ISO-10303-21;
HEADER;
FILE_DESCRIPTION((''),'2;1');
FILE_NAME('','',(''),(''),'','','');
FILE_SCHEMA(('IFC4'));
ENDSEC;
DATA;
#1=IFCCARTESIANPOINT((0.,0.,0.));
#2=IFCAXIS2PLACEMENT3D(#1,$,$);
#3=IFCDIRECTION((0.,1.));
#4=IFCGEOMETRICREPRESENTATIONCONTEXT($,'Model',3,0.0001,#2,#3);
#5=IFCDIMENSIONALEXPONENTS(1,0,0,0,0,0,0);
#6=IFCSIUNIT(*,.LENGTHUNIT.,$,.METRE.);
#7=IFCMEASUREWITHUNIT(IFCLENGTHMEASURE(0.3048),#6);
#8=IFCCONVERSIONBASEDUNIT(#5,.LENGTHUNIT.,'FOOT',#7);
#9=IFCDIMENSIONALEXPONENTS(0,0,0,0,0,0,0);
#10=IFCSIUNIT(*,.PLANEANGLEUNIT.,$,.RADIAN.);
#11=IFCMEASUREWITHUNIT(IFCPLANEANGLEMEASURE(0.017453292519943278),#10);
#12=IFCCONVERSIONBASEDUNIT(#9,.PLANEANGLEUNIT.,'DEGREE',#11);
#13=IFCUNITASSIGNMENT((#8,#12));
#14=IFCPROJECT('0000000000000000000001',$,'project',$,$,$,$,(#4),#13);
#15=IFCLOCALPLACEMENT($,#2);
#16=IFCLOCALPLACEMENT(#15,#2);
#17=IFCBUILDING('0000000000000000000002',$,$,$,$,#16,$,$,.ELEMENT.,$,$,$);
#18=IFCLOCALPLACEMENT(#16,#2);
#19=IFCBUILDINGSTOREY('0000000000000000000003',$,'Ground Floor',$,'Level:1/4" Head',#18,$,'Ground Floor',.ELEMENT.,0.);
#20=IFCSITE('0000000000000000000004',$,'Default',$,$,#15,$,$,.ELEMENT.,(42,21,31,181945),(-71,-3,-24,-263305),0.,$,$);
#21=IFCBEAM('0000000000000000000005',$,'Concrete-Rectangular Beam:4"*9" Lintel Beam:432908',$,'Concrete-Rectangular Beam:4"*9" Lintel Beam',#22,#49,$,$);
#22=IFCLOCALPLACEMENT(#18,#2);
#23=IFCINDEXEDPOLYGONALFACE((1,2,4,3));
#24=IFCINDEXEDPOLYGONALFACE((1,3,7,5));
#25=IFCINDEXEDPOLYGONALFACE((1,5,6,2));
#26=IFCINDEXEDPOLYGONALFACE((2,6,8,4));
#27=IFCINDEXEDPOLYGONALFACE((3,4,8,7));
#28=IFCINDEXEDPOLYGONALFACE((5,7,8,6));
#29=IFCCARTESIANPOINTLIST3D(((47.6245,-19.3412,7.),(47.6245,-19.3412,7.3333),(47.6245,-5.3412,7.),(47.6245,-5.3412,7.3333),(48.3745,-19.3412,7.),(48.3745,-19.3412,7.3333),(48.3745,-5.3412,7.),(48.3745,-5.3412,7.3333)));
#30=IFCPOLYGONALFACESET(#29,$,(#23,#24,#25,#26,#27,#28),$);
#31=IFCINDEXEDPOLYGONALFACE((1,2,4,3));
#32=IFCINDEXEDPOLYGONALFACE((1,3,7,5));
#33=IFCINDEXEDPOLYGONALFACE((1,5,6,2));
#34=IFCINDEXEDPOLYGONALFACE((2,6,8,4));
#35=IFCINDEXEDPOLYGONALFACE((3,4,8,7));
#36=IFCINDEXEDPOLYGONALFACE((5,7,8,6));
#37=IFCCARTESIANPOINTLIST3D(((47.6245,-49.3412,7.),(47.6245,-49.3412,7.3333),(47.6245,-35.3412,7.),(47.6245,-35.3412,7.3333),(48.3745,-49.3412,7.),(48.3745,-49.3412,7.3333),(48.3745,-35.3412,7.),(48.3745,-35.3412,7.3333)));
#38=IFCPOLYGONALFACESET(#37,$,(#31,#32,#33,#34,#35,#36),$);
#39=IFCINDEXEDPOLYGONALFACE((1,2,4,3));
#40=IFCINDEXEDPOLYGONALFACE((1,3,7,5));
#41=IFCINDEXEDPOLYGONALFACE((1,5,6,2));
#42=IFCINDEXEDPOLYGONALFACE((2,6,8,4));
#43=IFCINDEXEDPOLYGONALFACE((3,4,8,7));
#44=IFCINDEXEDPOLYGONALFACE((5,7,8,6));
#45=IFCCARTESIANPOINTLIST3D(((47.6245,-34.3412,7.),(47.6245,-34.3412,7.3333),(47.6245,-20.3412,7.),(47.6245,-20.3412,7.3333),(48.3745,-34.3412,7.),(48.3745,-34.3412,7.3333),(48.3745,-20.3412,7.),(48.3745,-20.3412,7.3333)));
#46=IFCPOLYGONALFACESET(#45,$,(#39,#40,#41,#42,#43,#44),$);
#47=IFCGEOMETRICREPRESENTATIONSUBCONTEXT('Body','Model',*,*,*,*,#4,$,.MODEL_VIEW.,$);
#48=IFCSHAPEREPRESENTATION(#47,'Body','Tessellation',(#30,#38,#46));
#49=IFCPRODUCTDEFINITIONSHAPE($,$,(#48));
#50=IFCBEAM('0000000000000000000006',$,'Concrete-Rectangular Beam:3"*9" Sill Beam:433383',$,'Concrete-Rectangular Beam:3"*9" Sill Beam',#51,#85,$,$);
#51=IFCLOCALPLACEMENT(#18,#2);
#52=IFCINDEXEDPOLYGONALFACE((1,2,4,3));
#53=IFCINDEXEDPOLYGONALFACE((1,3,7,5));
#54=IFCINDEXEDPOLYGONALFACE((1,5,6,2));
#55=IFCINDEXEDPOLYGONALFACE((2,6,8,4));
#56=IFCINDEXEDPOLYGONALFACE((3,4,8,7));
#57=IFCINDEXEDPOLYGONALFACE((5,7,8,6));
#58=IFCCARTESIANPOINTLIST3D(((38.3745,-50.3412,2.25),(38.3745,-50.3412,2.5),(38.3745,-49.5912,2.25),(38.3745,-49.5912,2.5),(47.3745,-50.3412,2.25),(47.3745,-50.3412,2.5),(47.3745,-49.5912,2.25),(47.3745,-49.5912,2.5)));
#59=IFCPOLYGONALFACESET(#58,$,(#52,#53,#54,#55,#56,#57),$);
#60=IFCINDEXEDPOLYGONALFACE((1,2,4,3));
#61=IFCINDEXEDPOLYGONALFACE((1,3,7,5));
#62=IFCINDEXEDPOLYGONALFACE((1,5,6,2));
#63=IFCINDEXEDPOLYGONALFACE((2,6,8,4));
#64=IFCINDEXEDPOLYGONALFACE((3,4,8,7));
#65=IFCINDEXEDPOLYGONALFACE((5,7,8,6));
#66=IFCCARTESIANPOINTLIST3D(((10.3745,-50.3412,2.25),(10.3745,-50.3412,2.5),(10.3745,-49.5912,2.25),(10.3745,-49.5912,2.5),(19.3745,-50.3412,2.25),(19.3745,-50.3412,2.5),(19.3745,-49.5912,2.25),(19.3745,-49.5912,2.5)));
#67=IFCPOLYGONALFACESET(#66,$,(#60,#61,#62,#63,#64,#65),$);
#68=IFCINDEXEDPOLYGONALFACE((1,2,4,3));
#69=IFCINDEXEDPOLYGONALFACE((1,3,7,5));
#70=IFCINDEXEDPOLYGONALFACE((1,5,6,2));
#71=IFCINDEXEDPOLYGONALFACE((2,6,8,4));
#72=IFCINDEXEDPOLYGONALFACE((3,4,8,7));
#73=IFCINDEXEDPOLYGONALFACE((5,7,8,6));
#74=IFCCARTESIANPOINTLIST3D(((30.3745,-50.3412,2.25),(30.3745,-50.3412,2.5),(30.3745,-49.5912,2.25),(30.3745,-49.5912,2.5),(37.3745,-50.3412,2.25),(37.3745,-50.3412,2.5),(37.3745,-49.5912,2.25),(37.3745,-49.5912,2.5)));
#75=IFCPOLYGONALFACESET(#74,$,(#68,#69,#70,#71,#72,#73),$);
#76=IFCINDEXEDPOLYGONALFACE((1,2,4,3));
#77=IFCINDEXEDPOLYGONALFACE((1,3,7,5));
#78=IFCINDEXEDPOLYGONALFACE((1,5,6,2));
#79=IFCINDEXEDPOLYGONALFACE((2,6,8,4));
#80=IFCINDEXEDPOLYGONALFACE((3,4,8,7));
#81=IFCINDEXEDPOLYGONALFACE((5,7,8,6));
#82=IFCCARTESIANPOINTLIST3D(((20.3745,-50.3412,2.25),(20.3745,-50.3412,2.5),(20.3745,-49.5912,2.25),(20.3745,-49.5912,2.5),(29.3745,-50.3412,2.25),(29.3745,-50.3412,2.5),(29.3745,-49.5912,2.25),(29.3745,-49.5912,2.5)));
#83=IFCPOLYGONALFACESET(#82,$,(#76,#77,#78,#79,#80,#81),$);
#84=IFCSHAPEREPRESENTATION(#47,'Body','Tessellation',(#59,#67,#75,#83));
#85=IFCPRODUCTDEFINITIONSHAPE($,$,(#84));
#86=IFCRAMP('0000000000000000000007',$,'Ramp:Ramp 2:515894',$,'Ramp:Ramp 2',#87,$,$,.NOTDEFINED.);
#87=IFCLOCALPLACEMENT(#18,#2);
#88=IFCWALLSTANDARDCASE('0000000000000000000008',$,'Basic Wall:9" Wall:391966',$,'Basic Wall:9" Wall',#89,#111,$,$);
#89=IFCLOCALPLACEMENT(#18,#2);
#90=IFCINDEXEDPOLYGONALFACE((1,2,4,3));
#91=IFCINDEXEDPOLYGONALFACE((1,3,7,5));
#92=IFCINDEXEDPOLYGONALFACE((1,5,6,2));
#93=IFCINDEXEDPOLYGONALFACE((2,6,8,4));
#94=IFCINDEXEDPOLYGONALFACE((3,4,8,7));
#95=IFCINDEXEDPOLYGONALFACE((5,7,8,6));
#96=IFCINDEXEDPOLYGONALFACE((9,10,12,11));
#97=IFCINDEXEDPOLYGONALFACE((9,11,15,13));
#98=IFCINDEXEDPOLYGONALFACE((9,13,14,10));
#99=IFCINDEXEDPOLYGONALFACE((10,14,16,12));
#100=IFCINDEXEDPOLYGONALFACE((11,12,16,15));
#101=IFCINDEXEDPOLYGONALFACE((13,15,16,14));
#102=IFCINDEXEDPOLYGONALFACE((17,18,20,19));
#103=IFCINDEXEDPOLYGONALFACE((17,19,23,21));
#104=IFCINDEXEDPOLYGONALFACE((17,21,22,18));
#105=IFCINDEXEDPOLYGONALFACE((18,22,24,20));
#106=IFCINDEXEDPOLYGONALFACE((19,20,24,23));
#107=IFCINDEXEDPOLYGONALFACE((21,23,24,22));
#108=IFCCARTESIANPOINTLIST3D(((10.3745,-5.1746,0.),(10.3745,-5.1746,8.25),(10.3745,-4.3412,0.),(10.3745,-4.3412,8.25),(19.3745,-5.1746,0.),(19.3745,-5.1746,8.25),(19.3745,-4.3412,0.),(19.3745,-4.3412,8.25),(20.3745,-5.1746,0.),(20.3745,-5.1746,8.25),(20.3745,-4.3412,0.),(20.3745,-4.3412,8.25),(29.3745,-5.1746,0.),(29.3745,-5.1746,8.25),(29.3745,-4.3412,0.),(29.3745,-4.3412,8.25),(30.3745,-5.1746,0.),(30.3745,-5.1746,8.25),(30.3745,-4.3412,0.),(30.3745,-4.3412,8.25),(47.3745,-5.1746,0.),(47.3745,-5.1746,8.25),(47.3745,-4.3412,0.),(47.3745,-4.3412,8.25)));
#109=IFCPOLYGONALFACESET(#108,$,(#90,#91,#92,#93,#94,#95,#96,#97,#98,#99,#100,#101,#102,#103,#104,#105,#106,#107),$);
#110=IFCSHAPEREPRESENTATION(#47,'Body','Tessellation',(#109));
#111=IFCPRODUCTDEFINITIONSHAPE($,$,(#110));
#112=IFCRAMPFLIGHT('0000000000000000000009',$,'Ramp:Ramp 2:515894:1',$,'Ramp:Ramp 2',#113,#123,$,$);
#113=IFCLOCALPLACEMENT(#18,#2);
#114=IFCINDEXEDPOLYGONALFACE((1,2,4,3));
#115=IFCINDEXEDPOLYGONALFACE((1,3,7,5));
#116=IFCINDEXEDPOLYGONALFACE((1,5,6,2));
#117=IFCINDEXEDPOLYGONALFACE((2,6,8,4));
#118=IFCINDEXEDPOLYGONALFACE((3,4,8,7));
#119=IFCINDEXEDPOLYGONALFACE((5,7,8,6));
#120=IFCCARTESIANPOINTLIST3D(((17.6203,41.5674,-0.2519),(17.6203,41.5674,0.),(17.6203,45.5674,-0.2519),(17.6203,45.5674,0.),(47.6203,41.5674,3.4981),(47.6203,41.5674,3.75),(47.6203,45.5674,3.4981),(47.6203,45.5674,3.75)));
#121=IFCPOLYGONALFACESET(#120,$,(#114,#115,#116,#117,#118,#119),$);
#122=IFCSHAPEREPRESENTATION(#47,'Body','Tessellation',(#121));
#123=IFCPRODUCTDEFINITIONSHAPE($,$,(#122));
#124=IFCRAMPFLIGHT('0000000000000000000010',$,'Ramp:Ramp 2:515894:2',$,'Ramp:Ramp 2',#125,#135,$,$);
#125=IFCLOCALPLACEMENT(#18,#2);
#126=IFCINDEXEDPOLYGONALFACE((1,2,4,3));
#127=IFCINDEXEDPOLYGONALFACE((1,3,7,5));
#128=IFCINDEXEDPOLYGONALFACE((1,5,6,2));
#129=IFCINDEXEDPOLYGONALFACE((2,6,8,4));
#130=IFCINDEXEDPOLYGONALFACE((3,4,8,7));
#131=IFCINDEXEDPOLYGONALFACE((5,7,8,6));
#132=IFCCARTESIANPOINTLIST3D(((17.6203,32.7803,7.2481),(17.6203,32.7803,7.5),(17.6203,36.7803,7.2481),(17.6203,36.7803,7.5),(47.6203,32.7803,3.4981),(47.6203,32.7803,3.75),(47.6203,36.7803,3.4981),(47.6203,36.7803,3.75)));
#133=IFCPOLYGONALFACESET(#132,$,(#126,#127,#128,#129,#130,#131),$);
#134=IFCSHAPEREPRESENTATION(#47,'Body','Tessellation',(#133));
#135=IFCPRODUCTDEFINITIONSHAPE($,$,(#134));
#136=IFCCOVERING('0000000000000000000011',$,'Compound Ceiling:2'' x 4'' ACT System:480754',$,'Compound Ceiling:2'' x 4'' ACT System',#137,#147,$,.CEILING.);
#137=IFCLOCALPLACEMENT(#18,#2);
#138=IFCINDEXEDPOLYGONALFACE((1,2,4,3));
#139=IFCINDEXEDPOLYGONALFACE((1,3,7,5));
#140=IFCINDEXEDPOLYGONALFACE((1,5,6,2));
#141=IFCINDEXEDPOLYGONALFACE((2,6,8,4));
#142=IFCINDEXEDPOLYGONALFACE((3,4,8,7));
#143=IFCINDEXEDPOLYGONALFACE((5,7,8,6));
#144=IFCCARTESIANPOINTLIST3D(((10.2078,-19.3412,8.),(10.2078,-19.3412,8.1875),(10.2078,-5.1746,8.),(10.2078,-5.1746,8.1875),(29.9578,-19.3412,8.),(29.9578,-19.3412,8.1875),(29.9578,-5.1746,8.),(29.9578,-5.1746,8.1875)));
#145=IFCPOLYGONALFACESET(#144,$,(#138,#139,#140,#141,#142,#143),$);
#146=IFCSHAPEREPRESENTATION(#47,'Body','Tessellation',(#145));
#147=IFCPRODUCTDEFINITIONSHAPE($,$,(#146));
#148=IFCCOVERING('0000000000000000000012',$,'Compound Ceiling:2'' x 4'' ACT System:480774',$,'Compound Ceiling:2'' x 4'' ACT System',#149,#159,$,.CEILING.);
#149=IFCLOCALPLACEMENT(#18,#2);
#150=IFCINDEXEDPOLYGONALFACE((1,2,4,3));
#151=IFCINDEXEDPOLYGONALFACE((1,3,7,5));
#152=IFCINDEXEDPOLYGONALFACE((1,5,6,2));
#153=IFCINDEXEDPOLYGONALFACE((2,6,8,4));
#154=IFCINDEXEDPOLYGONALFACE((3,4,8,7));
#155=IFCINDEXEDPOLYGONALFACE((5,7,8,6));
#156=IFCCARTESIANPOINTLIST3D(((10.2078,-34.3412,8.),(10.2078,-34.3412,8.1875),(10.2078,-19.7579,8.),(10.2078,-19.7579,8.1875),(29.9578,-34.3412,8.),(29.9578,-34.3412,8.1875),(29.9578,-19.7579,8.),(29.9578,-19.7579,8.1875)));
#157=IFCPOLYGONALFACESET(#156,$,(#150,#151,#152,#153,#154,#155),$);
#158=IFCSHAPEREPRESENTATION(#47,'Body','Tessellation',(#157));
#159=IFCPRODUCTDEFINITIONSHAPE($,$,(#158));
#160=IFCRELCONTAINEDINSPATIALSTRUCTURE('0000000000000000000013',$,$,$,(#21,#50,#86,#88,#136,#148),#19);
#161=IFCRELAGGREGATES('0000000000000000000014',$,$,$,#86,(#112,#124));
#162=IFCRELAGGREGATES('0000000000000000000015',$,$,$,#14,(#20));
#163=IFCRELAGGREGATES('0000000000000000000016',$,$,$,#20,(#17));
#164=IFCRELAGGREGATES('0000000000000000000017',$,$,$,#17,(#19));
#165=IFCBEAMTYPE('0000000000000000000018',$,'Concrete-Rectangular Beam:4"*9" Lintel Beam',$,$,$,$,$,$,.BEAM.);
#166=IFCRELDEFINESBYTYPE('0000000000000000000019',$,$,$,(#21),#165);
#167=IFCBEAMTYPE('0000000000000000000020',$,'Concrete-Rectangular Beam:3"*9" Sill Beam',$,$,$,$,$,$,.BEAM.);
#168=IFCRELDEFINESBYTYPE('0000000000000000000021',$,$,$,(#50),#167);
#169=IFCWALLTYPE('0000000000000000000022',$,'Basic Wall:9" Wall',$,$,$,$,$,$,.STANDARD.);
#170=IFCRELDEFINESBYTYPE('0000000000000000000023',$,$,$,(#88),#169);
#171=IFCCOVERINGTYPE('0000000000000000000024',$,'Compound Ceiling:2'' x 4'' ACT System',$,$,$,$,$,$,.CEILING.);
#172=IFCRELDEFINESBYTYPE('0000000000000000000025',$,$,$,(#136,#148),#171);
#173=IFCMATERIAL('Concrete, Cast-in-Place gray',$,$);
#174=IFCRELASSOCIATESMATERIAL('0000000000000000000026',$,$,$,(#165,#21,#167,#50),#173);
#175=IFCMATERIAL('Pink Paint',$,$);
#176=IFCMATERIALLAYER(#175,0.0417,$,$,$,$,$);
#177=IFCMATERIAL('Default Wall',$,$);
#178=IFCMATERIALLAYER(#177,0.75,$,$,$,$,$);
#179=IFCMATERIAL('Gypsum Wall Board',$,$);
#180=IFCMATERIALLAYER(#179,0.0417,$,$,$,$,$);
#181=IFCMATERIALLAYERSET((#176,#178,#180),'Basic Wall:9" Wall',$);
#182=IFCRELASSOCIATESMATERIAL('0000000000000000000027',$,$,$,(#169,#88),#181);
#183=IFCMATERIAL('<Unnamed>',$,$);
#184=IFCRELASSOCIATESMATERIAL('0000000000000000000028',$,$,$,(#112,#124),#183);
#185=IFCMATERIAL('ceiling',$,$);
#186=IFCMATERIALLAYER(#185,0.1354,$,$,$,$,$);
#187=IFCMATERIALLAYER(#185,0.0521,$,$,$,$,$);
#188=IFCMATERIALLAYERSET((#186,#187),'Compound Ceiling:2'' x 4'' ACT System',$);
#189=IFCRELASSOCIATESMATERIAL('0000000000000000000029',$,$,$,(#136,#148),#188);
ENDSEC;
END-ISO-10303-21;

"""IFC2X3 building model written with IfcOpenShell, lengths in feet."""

from ifc_helpers import new_model, entity, si_unit, converted_unit, direction, frame, frame_2d, origin, place, context, subcontext, project, spatial, polyline, rectangle, outline, extrude, clip, bounded_halfspace, source, transform, mapped, material, layer, layer_set, layer_usage, type_object, type_shapes, element, aggregate, save


model = new_model("IFC2X3")

# Units and contexts
model_context = context("Model", 3, precision=0.0001, world=origin(), true_north=direction((0.0, 1.0)))
body_context = subcontext(model_context, "Body", "Model", "MODEL_VIEW")
ifc_project = project(units=[converted_unit("LENGTHUNIT", "FOOT", entity("IfcLengthMeasure", 0.3048), si_unit("LENGTHUNIT", "METRE"), dimensions=[1, 0, 0, 0, 0, 0, 0]), converted_unit("PLANEANGLEUNIT", "DEGREE", entity("IfcPlaneAngleMeasure", 0.017453292519943278), si_unit("PLANEANGLEUNIT", "RADIAN"), dimensions=[0, 0, 0, 0, 0, 0, 0])], contexts=[model_context])

# Site, building, storey
site_placement = place(None, origin())
site = spatial("IfcSite", under=ifc_project, at=site_placement, Name="Default", CompositionType="ELEMENT", RefLatitude=(42, 21, 31, 181945), RefLongitude=(-71, -3, -24, -263305), RefElevation=0.0)
building_placement = place(site_placement, origin())
building = spatial("IfcBuilding", under=site, at=building_placement, CompositionType="ELEMENT")
storey_placement = place(building_placement, origin())
storey = spatial("IfcBuildingStorey", under=building, at=storey_placement, Name="Ground Floor", ObjectType="Level:1/4\" Head", LongName="Ground Floor", CompositionType="ELEMENT", Elevation=0.0)

# Beams
ifc_material_1 = material(Name="Concrete, Cast-in-Place gray")
beam_type_1 = type_object("IfcBeamType", Name="Concrete-Rectangular Beam:4\"*9\" Lintel Beam", PredefinedType="BEAM", material=ifc_material_1)
shared_shape_1 = source(origin(), body_context, "Body", "SweptSolid", [
    extrude(rectangle(XDim=0.3333, YDim=0.75, at=frame_2d((0.0, 0.0), x_axis=(0.0, 1.0))), frame((47.9995, -19.3412, 7.1667), z_axis=(0.0, 1.0, 0.0), x_axis=(-1.0, 0.0, 0.0)), (0.0, 0.0, 1.0), 14.0),
    extrude(rectangle(XDim=0.3333, YDim=0.75, at=frame_2d((0.0, 0.0), x_axis=(0.0, 1.0))), frame((47.9995, -49.3412, 7.1667), z_axis=(0.0, 1.0, 0.0), x_axis=(-1.0, 0.0, 0.0)), (0.0, 0.0, 1.0), 14.0),
    extrude(rectangle(XDim=0.3333, YDim=0.75, at=frame_2d((0.0, 0.0), x_axis=(0.0, 1.0))), frame((47.9995, -34.3412, 7.1667), z_axis=(0.0, 1.0, 0.0), x_axis=(-1.0, 0.0, 0.0)), (0.0, 0.0, 1.0), 14.0),
])
type_shapes(beam_type_1, [shared_shape_1])
beam_1_placement = place(storey_placement, origin())
element("IfcBeam", 1, at=beam_1_placement, inside=storey, type_object=beam_type_1, material=ifc_material_1, Name="Concrete-Rectangular Beam:4\"*9\" Lintel Beam:432908", ObjectType="Concrete-Rectangular Beam:4\"*9\" Lintel Beam", context=body_context, shape_type="MappedRepresentation", body=[
    mapped(shared_shape_1, transform((0.0, 0.0, 0.0), scale=1.0)),
])
beam_type_2 = type_object("IfcBeamType", Name="Concrete-Rectangular Beam:3\"*9\" Sill Beam", PredefinedType="BEAM", material=ifc_material_1)
shared_shape_2 = source(origin(), body_context, "Body", "SweptSolid", [
    extrude(rectangle(XDim=0.25, YDim=0.75, at=frame_2d((0.0, 0.0), x_axis=(1.0, 0.0))), frame((38.3745, -49.9662, 2.375), z_axis=(1.0, 0.0, 0.0), x_axis=(0.0, 0.0, -1.0)), (0.0, 0.0, 1.0), 9.0),
    extrude(rectangle(XDim=0.25, YDim=0.75, at=frame_2d((0.0, 0.0), x_axis=(1.0, 0.0))), frame((10.3745, -49.9662, 2.375), z_axis=(1.0, 0.0, 0.0), x_axis=(0.0, 0.0, -1.0)), (0.0, 0.0, 1.0), 9.0),
    extrude(rectangle(XDim=0.25, YDim=0.75, at=frame_2d((0.0, 0.0), x_axis=(1.0, 0.0))), frame((30.3745, -49.9662, 2.375), z_axis=(1.0, 0.0, 0.0), x_axis=(0.0, 0.0, -1.0)), (0.0, 0.0, 1.0), 7.0),
    extrude(rectangle(XDim=0.25, YDim=0.75, at=frame_2d((0.0, 0.0), x_axis=(1.0, 0.0))), frame((20.3745, -49.9662, 2.375), z_axis=(1.0, 0.0, 0.0), x_axis=(0.0, 0.0, -1.0)), (0.0, 0.0, 1.0), 9.0),
])
type_shapes(beam_type_2, [shared_shape_2])
beam_2_placement = place(storey_placement, origin())
element("IfcBeam", 2, at=beam_2_placement, inside=storey, type_object=beam_type_2, material=ifc_material_1, Name="Concrete-Rectangular Beam:3\"*9\" Sill Beam:433383", ObjectType="Concrete-Rectangular Beam:3\"*9\" Sill Beam", context=body_context, shape_type="MappedRepresentation", body=[
    mapped(shared_shape_2, transform((0.0, 0.0, 0.0), scale=1.0)),
])

# Shared definitions
ifc_material_2 = material(Name="<Unnamed>")

# Ramp
ramp_1_placement = place(storey_placement, origin())
ramp_1 = element("IfcRamp", 3, at=ramp_1_placement, inside=storey, Name="Ramp:Ramp 2:515894", ObjectType="Ramp:Ramp 2", ShapeType="NOTDEFINED")

# Wall, openings
ifc_material_3 = material(Name="Pink Paint")
ifc_layer_1 = layer(ifc_material_3, 0.0417)
ifc_material_4 = material(Name="Default Wall")
ifc_layer_2 = layer(ifc_material_4, 0.75)
ifc_material_5 = material(Name="Gypsum Wall Board")
ifc_layer_3 = layer(ifc_material_5, 0.0417)
ifc_layer_set_1 = layer_set([ifc_layer_1, ifc_layer_2, ifc_layer_3], Name="Basic Wall:9\" Wall")
ifc_layer_usage_1 = layer_usage(ifc_layer_set_1, "AXIS2", "NEGATIVE", 0.4167)
wall_type = type_object("IfcWallType", Name="Basic Wall:9\" Wall", PredefinedType="STANDARD", material=ifc_layer_set_1)
wall_placement = place(storey_placement, frame((10.3745, -4.7579, 0.0)))
wall = element("IfcWallStandardCase", 4, at=wall_placement, inside=storey, type_object=wall_type, material=ifc_layer_usage_1, Name="Basic Wall:9\" Wall:391966", ObjectType="Basic Wall:9\" Wall", context=body_context, shape_type="Clipping", body=[
    clip(clip(extrude(rectangle(XDim=37.0, YDim=0.8333, at=frame_2d((18.5, 0.0), x_axis=(-1.0, 0.0))), origin(), (0.0, 0.0, 1.0), 8.25), bounded_halfspace(frame((0.0, -0.4167, 0.0), z_axis=(1.0, 0.0, 0.0), x_axis=(0.0, 0.0, -1.0)), True, frame((0.0, -0.4167, 0.0), z_axis=(1.0, 0.0, 0.0), x_axis=(0.0, 0.0, -1.0)), polyline([(0.0, 0.0), (0.0, 0.8333), (-8.25, 0.8333), (-8.25, 0.0), (0.0, 0.0)]))), bounded_halfspace(frame((37.0, -0.4167, 8.25), z_axis=(-1.0, 0.0, 0.0), x_axis=(0.0, 0.0, -1.0)), True, frame((37.0, -0.4167, 8.25), z_axis=(-1.0, 0.0, 0.0), x_axis=(0.0, 0.0, -1.0)), polyline([(0.0, 0.0), (0.0, -0.8333), (8.25, -0.8333), (8.25, 0.0), (0.0, 0.0)]))),
])
opening_1_placement = place(storey_placement, frame((10.3745, -4.7579, 0.0)))
element("IfcOpeningElement", 5, at=opening_1_placement, cuts=wall, ObjectType="Opening", context=body_context, shape_type="SweptSolid", body=[
    extrude(rectangle(XDim=8.25, YDim=0.8333, at=frame_2d((0.0, 0.0), x_axis=(1.0, 0.0))), frame((9.0, 0.0, 4.125), z_axis=(1.0, 0.0, 0.0), x_axis=(0.0, 0.0, -1.0)), (0.0, 0.0, 1.0), 1.0),
])
opening_2_placement = place(storey_placement, frame((10.3745, -4.7579, 0.0)))
element("IfcOpeningElement", 6, at=opening_2_placement, cuts=wall, ObjectType="Opening", context=body_context, shape_type="SweptSolid", body=[
    extrude(rectangle(XDim=8.25, YDim=0.8333, at=frame_2d((0.0, 0.0), x_axis=(1.0, 0.0))), frame((19.0, 0.0, 4.125), z_axis=(1.0, 0.0, 0.0), x_axis=(0.0, 0.0, -1.0)), (0.0, 0.0, 1.0), 1.0),
])

# Ramp flights
ramp_flight_1_placement = place(ramp_1_placement, origin())
ramp_flight_1 = element("IfcRampFlight", 7, at=ramp_flight_1_placement, material=ifc_material_2, Name="Ramp:Ramp 2:515894:1", ObjectType="Ramp:Ramp 2", context=body_context, shape_type="SweptSolid", body=[
    extrude(outline(polyline([(-2.001, -15.0), (-1.749, -15.0), (2.001, 15.0), (1.749, 15.0), (-2.001, -15.0)])), frame((32.6203, 41.5674, 1.749), z_axis=(0.0, 1.0, 0.0), x_axis=(0.0, 0.0, -1.0)), (0.0, 0.0, 1.0), 4.0),
])
ramp_flight_2_placement = place(ramp_1_placement, origin())
ramp_flight_2 = element("IfcRampFlight", 8, at=ramp_flight_2_placement, material=ifc_material_2, Name="Ramp:Ramp 2:515894:2", ObjectType="Ramp:Ramp 2", context=body_context, shape_type="SweptSolid", body=[
    extrude(outline(polyline([(1.749, -15.0), (2.001, -15.0), (-1.749, 15.0), (-2.001, 15.0), (1.749, -15.0)])), frame((32.6203, 32.7803, 5.499), z_axis=(0.0, 1.0, 0.0), x_axis=(0.0, 0.0, -1.0)), (0.0, 0.0, 1.0), 4.0),
])
aggregate(ramp_1, [ramp_flight_1, ramp_flight_2])

# Coverings
ifc_material_6 = material(Name="ceiling")
ifc_layer_4 = layer(ifc_material_6, 0.1354)
ifc_layer_5 = layer(ifc_material_6, 0.0521)
ifc_layer_set_2 = layer_set([ifc_layer_4, ifc_layer_5], Name="Compound Ceiling:2' x 4' ACT System")
ifc_layer_usage_2 = layer_usage(ifc_layer_set_2, "AXIS3", "NEGATIVE", 0.1875)
covering_type = type_object("IfcCoveringType", Name="Compound Ceiling:2' x 4' ACT System", PredefinedType="CEILING")
covering_1_placement = place(storey_placement, origin())
element("IfcCovering", 9, at=covering_1_placement, inside=storey, type_object=covering_type, material=ifc_layer_usage_2, Name="Compound Ceiling:2' x 4' ACT System:480754", ObjectType="Compound Ceiling:2' x 4' ACT System", PredefinedType="CEILING", context=body_context, shape_type="SweptSolid", body=[
    extrude(rectangle(XDim=14.1667, YDim=19.75, at=frame_2d((0.0, 0.0), x_axis=(1.0, 0.0))), frame((20.0828, -12.2579, 8.0), z_axis=(0.0, 0.0, 1.0), x_axis=(0.0, -1.0, 0.0)), (0.0, 0.0, 1.0), 0.1875),
])
covering_2_placement = place(storey_placement, origin())
element("IfcCovering", 10, at=covering_2_placement, inside=storey, type_object=covering_type, material=ifc_layer_usage_2, Name="Compound Ceiling:2' x 4' ACT System:480774", ObjectType="Compound Ceiling:2' x 4' ACT System", PredefinedType="CEILING", context=body_context, shape_type="SweptSolid", body=[
    extrude(rectangle(XDim=19.75, YDim=14.5833, at=frame_2d((0.0, 0.0), x_axis=(1.0, 0.0))), frame((20.0828, -27.0496, 8.0)), (0.0, 0.0, 1.0), 0.1875),
])

save(model, "model.ifc")
